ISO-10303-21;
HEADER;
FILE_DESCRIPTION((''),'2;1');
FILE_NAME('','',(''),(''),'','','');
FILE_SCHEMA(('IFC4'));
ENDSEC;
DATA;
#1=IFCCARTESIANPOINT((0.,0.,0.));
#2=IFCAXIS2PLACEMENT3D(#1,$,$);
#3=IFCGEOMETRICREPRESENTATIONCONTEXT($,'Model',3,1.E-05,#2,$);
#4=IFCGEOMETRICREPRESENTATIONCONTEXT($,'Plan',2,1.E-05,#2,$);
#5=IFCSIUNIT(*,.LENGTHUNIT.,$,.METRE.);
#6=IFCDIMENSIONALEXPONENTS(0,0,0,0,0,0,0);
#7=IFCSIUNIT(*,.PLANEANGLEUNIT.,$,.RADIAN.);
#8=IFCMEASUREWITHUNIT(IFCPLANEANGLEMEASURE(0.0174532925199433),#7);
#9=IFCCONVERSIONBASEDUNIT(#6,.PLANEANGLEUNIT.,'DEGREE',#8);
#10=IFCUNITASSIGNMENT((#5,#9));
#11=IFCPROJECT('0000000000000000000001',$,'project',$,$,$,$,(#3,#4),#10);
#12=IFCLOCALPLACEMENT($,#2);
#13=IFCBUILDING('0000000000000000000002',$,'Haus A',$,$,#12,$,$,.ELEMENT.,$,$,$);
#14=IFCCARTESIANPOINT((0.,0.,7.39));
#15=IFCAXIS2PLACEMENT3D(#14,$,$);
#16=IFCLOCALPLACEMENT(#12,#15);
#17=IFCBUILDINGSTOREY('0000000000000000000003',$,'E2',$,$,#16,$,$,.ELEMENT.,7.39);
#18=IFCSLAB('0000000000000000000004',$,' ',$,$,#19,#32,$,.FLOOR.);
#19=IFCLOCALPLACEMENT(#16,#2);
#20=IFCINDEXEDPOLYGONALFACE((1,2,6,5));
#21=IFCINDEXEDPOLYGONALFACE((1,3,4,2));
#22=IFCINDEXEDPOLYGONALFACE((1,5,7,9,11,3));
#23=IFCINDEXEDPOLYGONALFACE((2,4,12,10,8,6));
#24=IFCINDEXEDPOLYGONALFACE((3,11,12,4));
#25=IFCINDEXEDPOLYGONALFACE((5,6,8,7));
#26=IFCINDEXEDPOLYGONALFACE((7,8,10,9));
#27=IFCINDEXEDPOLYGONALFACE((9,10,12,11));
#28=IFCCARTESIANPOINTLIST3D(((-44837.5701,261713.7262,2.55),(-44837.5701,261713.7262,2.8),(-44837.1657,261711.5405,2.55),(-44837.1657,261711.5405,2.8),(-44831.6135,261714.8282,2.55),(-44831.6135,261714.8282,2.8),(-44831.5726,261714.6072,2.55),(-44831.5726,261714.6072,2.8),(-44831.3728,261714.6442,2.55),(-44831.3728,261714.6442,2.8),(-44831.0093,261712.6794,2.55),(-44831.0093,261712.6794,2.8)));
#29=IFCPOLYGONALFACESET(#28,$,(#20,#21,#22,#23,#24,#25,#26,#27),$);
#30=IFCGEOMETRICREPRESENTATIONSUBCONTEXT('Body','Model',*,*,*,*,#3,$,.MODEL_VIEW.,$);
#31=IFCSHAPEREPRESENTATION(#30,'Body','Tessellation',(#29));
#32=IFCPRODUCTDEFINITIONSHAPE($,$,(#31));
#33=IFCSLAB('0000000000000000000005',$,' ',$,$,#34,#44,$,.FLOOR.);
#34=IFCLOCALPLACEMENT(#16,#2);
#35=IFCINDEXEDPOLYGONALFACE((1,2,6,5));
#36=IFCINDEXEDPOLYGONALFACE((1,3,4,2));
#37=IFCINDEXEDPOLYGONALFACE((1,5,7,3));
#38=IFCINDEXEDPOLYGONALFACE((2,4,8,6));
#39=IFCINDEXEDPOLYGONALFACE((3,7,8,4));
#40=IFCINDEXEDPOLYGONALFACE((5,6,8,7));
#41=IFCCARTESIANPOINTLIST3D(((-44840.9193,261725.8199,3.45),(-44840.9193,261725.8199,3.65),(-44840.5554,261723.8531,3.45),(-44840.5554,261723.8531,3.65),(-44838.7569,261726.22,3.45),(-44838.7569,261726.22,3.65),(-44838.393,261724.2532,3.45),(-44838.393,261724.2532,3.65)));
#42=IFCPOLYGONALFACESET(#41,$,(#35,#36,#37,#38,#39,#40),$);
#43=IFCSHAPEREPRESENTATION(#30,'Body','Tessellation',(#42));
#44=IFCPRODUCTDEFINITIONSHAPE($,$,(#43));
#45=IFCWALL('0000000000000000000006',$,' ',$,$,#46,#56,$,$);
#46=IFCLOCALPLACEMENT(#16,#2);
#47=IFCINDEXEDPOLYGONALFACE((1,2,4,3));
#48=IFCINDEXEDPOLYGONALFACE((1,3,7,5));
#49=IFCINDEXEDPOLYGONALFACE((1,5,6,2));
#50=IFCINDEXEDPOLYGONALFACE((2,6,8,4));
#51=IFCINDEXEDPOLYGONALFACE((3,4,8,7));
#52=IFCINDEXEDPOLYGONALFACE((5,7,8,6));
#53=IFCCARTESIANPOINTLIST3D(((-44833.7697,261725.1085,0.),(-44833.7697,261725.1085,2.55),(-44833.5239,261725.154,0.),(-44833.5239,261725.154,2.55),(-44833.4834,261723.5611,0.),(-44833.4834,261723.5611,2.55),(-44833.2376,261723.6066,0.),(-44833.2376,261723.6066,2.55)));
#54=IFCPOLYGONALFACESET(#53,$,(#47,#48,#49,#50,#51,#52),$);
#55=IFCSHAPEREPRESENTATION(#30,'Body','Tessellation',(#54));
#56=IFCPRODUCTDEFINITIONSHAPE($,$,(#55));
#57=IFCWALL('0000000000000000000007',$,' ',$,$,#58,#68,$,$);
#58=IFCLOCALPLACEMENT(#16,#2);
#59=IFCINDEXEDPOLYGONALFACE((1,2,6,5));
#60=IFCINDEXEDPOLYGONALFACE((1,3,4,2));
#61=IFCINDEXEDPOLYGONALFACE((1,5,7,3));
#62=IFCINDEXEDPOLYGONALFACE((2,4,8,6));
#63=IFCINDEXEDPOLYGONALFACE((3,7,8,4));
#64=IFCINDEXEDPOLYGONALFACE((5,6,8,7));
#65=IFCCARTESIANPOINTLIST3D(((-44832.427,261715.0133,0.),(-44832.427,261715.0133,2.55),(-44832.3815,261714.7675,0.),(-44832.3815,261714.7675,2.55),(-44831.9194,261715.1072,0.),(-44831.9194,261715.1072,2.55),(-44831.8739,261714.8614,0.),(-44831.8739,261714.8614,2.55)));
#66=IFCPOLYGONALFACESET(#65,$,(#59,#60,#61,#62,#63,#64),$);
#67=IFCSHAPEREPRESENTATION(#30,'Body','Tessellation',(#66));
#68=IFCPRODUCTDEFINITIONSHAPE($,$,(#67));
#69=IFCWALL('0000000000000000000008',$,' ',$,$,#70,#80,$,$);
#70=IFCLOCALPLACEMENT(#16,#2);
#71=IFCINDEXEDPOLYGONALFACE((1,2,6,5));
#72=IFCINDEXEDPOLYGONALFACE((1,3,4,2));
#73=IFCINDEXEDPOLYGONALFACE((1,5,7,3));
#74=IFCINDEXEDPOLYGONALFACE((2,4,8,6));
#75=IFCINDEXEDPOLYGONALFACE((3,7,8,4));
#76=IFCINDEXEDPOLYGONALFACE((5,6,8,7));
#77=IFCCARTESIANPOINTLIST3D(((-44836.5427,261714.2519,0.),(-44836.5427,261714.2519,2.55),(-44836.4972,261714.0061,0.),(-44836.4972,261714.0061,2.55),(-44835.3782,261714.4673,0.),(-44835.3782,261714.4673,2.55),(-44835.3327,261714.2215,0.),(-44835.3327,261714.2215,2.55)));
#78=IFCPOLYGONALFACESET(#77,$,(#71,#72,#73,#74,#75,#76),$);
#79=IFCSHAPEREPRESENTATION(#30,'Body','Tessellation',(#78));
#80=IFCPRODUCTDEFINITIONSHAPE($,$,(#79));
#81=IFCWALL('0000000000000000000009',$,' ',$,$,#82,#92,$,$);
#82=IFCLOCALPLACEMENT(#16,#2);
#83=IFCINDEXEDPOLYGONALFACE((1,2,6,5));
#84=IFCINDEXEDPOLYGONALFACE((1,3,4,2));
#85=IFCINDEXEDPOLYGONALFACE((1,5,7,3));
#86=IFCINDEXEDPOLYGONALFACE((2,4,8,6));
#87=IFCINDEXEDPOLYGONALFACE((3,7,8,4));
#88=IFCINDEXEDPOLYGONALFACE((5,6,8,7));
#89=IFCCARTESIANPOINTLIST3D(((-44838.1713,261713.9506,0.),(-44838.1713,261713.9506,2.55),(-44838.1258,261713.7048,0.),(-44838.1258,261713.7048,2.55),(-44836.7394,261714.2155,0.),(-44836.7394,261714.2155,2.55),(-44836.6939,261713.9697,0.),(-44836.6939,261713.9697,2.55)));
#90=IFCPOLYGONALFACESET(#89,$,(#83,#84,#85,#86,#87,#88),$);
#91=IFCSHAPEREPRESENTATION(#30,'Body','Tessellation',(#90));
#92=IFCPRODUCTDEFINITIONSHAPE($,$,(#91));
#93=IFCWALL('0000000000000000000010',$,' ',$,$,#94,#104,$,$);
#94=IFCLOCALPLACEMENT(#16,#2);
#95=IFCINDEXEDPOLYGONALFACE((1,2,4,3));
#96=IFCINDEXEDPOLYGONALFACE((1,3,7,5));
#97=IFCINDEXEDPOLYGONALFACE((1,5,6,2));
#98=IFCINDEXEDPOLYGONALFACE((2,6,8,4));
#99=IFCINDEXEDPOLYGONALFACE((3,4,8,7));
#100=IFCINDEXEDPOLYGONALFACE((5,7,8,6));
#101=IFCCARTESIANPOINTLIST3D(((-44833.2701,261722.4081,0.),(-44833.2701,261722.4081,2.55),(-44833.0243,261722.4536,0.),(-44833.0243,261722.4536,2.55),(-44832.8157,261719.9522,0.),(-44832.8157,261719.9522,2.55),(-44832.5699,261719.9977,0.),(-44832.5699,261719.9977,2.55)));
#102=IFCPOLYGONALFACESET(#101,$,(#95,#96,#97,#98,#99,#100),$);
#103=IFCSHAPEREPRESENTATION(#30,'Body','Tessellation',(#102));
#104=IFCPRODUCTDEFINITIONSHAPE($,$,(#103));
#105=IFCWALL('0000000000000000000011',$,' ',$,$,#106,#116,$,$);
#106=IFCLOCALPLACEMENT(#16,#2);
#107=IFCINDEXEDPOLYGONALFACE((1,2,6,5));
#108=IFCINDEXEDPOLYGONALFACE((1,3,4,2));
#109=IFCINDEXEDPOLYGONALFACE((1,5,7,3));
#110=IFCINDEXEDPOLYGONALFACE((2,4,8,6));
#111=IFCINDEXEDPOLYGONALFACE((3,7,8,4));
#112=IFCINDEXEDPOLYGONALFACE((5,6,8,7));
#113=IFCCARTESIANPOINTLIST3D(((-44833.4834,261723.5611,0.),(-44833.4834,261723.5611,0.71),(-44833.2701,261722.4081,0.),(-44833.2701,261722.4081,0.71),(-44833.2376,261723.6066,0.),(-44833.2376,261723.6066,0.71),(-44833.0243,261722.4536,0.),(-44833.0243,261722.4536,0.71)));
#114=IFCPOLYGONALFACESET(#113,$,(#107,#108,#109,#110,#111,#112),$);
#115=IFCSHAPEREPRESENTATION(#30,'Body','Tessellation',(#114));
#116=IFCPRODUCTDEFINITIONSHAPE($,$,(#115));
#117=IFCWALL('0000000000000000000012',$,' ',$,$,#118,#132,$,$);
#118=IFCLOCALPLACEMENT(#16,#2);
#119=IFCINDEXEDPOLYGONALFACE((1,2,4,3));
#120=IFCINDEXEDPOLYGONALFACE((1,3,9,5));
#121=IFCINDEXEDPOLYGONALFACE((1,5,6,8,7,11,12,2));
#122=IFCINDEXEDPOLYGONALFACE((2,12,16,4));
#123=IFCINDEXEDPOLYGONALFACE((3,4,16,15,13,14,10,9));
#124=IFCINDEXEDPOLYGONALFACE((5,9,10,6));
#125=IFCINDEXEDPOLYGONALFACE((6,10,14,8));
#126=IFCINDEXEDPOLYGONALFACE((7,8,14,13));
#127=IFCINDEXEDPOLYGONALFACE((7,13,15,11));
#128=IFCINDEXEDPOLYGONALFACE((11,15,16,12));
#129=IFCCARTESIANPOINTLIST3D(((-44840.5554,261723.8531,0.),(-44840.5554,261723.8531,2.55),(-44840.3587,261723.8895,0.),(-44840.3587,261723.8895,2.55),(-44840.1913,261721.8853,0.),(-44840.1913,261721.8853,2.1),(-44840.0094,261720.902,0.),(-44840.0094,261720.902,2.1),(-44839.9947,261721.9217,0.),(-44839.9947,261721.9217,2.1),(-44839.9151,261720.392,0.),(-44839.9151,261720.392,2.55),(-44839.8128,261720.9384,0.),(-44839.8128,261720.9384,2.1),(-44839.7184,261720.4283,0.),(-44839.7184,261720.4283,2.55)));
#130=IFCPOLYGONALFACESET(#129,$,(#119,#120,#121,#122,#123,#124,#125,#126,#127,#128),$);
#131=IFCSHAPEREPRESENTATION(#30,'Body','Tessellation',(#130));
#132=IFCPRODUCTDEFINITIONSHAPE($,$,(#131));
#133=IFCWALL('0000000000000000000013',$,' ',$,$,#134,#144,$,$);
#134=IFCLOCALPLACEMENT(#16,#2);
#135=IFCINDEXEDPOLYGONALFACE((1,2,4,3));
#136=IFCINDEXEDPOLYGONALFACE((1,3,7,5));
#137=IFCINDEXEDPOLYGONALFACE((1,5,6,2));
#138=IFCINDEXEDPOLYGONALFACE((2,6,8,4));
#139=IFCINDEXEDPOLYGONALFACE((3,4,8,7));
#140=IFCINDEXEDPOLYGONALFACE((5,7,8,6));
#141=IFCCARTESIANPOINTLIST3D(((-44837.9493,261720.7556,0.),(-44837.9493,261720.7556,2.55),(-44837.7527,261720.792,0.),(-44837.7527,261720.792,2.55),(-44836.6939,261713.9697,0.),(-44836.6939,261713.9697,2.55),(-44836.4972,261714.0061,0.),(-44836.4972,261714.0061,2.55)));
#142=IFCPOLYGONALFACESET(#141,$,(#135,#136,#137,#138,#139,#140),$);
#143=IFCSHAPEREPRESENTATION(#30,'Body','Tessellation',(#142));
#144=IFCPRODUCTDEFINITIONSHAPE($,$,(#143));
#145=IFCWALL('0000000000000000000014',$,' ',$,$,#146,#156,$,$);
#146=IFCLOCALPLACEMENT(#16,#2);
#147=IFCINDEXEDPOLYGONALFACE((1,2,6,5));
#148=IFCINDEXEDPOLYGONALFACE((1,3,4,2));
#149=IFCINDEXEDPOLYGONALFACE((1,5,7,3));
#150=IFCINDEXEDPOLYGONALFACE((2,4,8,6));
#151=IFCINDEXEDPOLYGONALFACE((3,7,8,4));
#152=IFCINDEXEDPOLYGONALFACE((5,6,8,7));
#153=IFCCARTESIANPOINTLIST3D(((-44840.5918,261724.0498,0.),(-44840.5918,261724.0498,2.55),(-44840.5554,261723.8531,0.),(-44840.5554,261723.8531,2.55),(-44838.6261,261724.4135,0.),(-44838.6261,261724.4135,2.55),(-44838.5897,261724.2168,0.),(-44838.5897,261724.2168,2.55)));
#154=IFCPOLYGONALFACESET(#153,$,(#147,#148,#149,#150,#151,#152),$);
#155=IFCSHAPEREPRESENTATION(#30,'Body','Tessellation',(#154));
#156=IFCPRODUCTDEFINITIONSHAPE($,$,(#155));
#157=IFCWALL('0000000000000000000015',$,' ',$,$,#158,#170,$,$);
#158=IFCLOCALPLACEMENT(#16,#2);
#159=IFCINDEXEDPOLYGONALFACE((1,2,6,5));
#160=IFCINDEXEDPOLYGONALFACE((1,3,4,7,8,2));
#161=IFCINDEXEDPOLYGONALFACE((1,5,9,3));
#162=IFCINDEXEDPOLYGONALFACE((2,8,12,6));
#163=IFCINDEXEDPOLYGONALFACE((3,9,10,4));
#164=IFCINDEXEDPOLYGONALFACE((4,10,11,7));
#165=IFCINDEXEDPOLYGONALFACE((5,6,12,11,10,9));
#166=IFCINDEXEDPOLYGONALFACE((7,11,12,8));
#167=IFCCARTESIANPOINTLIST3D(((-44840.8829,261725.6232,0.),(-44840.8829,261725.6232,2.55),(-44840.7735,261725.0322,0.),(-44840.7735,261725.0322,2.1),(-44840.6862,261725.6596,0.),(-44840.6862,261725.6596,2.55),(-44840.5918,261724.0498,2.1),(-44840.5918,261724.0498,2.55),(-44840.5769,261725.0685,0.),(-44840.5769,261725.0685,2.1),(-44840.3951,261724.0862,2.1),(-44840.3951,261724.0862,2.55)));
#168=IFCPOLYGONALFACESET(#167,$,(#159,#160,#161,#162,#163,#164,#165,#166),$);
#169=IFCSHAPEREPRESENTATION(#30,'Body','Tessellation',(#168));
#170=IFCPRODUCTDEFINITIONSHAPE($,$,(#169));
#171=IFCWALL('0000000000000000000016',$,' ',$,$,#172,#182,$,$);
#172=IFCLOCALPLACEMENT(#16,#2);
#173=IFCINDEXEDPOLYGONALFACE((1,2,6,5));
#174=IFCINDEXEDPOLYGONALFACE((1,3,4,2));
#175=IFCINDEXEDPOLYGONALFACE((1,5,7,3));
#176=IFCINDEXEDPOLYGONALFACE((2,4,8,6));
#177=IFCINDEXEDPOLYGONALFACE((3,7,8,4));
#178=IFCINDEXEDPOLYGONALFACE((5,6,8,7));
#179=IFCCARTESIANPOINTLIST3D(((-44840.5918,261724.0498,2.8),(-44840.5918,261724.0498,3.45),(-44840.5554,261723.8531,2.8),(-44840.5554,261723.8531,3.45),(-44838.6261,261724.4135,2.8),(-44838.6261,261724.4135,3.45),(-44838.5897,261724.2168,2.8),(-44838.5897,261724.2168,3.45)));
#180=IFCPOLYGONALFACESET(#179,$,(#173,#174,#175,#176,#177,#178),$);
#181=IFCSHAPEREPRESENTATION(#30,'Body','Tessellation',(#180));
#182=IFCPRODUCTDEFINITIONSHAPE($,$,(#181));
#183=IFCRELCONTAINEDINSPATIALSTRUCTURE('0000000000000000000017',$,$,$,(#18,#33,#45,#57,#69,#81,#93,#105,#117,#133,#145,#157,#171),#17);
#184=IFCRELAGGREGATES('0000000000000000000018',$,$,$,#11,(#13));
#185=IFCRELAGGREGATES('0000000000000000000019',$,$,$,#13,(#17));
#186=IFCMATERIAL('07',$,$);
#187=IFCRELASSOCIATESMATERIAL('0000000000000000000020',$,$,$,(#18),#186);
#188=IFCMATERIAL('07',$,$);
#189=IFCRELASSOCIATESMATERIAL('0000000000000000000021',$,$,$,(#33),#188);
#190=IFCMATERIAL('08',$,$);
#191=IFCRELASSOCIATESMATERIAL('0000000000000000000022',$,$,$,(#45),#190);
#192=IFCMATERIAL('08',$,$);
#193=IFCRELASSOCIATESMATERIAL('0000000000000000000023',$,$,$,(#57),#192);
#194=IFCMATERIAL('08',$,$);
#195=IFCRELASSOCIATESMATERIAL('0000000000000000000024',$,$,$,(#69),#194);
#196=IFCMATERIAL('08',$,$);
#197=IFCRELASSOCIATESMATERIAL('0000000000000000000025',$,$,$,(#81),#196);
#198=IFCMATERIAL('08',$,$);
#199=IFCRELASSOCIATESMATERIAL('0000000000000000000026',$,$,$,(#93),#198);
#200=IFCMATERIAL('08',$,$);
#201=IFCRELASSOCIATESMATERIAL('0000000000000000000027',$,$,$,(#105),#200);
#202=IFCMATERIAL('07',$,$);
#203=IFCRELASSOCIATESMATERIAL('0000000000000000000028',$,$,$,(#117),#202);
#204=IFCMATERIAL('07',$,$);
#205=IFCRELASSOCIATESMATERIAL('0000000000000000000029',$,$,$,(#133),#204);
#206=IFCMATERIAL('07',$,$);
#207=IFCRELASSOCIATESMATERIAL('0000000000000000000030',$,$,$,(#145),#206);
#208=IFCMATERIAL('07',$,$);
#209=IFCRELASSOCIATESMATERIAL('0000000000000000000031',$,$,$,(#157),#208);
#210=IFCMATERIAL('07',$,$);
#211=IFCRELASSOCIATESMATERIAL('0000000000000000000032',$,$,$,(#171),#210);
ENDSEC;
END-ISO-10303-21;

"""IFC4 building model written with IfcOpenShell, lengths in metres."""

from ifc_helpers import new_model, entity, si_unit, converted_unit, frame, frame_2d, origin, origin_with_axes, place, context, subcontext, project, spatial, polyline, rectangle, outline, extrude, material, element, save


model = new_model("IFC4")

# Units and contexts
model_context = context("Model", 3, precision=1e-05, world=origin())
plan_context = context("Plan", 2, precision=1e-05, world=origin())
body_context = subcontext(model_context, "Body", "Model", "MODEL_VIEW")
ifc_project = project(units=[si_unit("LENGTHUNIT", "METRE"), converted_unit("PLANEANGLEUNIT", "DEGREE", entity("IfcPlaneAngleMeasure", 0.0174532925199433), si_unit("PLANEANGLEUNIT", "RADIAN"), dimensions=[0, 0, 0, 0, 0, 0, 0])], contexts=[model_context, plan_context])

# Building, storey
building_placement = place(None, origin())
building = spatial("IfcBuilding", under=ifc_project, at=building_placement, Name="Haus A", CompositionType="ELEMENT")
storey_placement = place(building_placement, frame((0.0, 0.0, 7.39)))
storey = spatial("IfcBuildingStorey", under=building, at=storey_placement, Name="E2", CompositionType="ELEMENT", Elevation=7.39)

# Slabs
ifc_material_1 = material(Name="07")
slab_1_placement = place(storey_placement, frame((-44837.5701, 261711.5405, 2.55)))
element("IfcSlab", 1, at=slab_1_placement, inside=storey, material=ifc_material_1, Name=" ", PredefinedType="FLOOR", context=body_context, shape_type="SweptSolid", body=[
    extrude(outline(polyline([(0.0, 2.1858), (0.4044, 0.0), (6.5608, 1.139), (6.1973, 3.1037), (5.9975, 3.0667), (5.9566, 3.2878), (0.0, 2.1858)])), origin_with_axes(), (0.0, 0.0, 1.0), 0.25),
])
ifc_material_2 = material(Name="07")
slab_2_placement = place(storey_placement, frame((-44840.9193, 261723.8531, 3.45)))
element("IfcSlab", 2, at=slab_2_placement, inside=storey, material=ifc_material_2, Name=" ", PredefinedType="FLOOR", context=body_context, shape_type="SweptSolid", body=[
    extrude(rectangle(XDim=2.0001, YDim=2.1991, at=frame_2d((1.2631, -0.7834), x_axis=(0.18192, -0.983313))), frame((0.0, 1.9668, 0.0), z_axis=(0.0, 0.0, 1.0), x_axis=(1.0, 0.0, 0.0)), (0.0, 0.0, 1.0), 0.2),
])

# Walls
ifc_material_3 = material(Name="08")
wall_1_placement = place(storey_placement, frame((-44833.2376, 261723.6066, 0.0), z_axis=(0.0, 0.0, 1.0), x_axis=(-0.18192, 0.983313, 0.0)))
element("IfcWall", 3, at=wall_1_placement, inside=storey, material=ifc_material_3, Name=" ", context=body_context, shape_type="SweptSolid", body=[
    extrude(rectangle(XDim=1.5737, YDim=0.25, at=frame_2d((0.7868, 0.125), x_axis=(1.0, 0.0))), origin_with_axes(), (0.0, 0.0, 1.0), 2.55),
])
ifc_material_4 = material(Name="08")
wall_2_placement = place(storey_placement, frame((-44832.3815, 261714.7675, 0.0), z_axis=(0.0, 0.0, 1.0), x_axis=(0.983313, 0.18192, 0.0)))
element("IfcWall", 4, at=wall_2_placement, inside=storey, material=ifc_material_4, Name=" ", context=body_context, shape_type="SweptSolid", body=[
    extrude(rectangle(XDim=0.5162, YDim=0.25, at=frame_2d((0.2581, 0.125), x_axis=(1.0, 0.0))), origin_with_axes(), (0.0, 0.0, 1.0), 2.55),
])
ifc_material_5 = material(Name="08")
wall_3_placement = place(storey_placement, frame((-44836.4972, 261714.0061, 0.0), z_axis=(0.0, 0.0, 1.0), x_axis=(0.983313, 0.18192, 0.0)))
element("IfcWall", 5, at=wall_3_placement, inside=storey, material=ifc_material_5, Name=" ", context=body_context, shape_type="SweptSolid", body=[
    extrude(rectangle(XDim=1.1842, YDim=0.25, at=frame_2d((0.5921, 0.125), x_axis=(1.0, 0.0))), origin_with_axes(), (0.0, 0.0, 1.0), 2.55),
])
ifc_material_6 = material(Name="08")
wall_4_placement = place(storey_placement, frame((-44838.1258, 261713.7048, 0.0), z_axis=(0.0, 0.0, 1.0), x_axis=(0.983313, 0.18192, 0.0)))
element("IfcWall", 6, at=wall_4_placement, inside=storey, material=ifc_material_6, Name=" ", context=body_context, shape_type="SweptSolid", body=[
    extrude(rectangle(XDim=1.4562, YDim=0.25, at=frame_2d((0.7281, 0.125), x_axis=(1.0, 0.0))), origin_with_axes(), (0.0, 0.0, 1.0), 2.55),
])
ifc_material_7 = material(Name="08")
wall_5_placement = place(storey_placement, frame((-44832.5699, 261719.9977, 0.0), z_axis=(0.0, 0.0, 1.0), x_axis=(-0.18192, 0.983313, 0.0)))
element("IfcWall", 7, at=wall_5_placement, inside=storey, material=ifc_material_7, Name=" ", context=body_context, shape_type="SweptSolid", body=[
    extrude(rectangle(XDim=2.4976, YDim=0.25, at=frame_2d((1.2488, 0.125), x_axis=(1.0, 0.0))), origin_with_axes(), (0.0, 0.0, 1.0), 2.55),
])
ifc_material_8 = material(Name="08")
wall_6_placement = place(storey_placement, frame((-44833.0243, 261722.4536, 0.0), z_axis=(0.0, 0.0, 1.0), x_axis=(-0.18192, 0.983313, 0.0)))
element("IfcWall", 8, at=wall_6_placement, inside=storey, material=ifc_material_8, Name=" ", context=body_context, shape_type="SweptSolid", body=[
    extrude(rectangle(XDim=1.1726, YDim=0.25, at=frame_2d((0.5863, 0.125), x_axis=(1.0, 0.0))), origin_with_axes(), (0.0, 0.0, 1.0), 0.71),
])

# Wall, opening
ifc_material_9 = material(Name="07")
wall_7_placement = place(storey_placement, frame((-44839.7184, 261720.4283, 0.0), z_axis=(0.0, 0.0, 1.0), x_axis=(-0.18192, 0.983313, 0.0)))
wall_7 = element("IfcWall", 9, at=wall_7_placement, inside=storey, material=ifc_material_9, Name=" ", context=body_context, shape_type="SweptSolid", body=[
    extrude(rectangle(XDim=3.5199, YDim=0.2, at=frame_2d((1.76, 0.1), x_axis=(1.0, 0.0))), origin_with_axes(), (0.0, 0.0, 1.0), 2.55),
])
opening_1_placement = place(wall_7_placement, frame((0.5187, 0.0, 0.0), z_axis=(0.0, 1.0, 0.0), x_axis=(0.0, 0.0, 1.0)))
element("IfcOpeningElement", 10, at=opening_1_placement, cuts=wall_7, ObjectType="Opening", context=body_context, shape_type="SweptSolid", body=[
    extrude(outline(polyline([(0.0, 1.0), (2.1, 1.0), (2.1, 0.0), (0.0, 0.0), (0.0, 1.0)])), origin_with_axes(), (0.0, 0.0, 1.0), 0.2),
])

# Walls
ifc_material_10 = material(Name="07")
wall_8_placement = place(storey_placement, frame((-44837.9493, 261720.7556, 0.0), z_axis=(0.0, 0.0, 1.0), x_axis=(0.18192, -0.983313, 0.0)))
element("IfcWall", 11, at=wall_8_placement, inside=storey, material=ifc_material_10, Name=" ", context=body_context, shape_type="SweptSolid", body=[
    extrude(rectangle(XDim=6.9011, YDim=0.2, at=frame_2d((3.4506, 0.1), x_axis=(1.0, 0.0))), origin_with_axes(), (0.0, 0.0, 1.0), 2.55),
])
ifc_material_11 = material(Name="07")
wall_9_placement = place(storey_placement, frame((-44838.6261, 261724.4135, 0.0), z_axis=(0.0, 0.0, 1.0), x_axis=(-0.983313, -0.18192, 0.0)))
element("IfcWall", 12, at=wall_9_placement, inside=storey, material=ifc_material_11, Name=" ", context=body_context, shape_type="SweptSolid", body=[
    extrude(rectangle(XDim=1.9991, YDim=0.2, at=frame_2d((0.9995, 0.1), x_axis=(1.0, 0.0))), origin_with_axes(), (0.0, 0.0, 1.0), 2.55),
])

# Wall, opening
ifc_material_12 = material(Name="07")
wall_10_placement = place(storey_placement, frame((-44840.3951, 261724.0862, 0.0), z_axis=(0.0, 0.0, 1.0), x_axis=(-0.18192, 0.983313, 0.0)))
wall_10 = element("IfcWall", 13, at=wall_10_placement, inside=storey, material=ifc_material_12, Name=" ", context=body_context, shape_type="SweptSolid", body=[
    extrude(rectangle(XDim=1.6001, YDim=0.2, at=frame_2d((0.8001, 0.1), x_axis=(1.0, 0.0))), origin_with_axes(), (0.0, 0.0, 1.0), 2.55),
])
opening_2_placement = place(wall_10_placement, frame((0.0, 0.0, 0.0), z_axis=(0.0, 1.0, 0.0), x_axis=(0.0, 0.0, 1.0)))
element("IfcOpeningElement", 14, at=opening_2_placement, cuts=wall_10, ObjectType="Opening", context=body_context, shape_type="SweptSolid", body=[
    extrude(outline(polyline([(0.0, 0.999), (2.1, 0.999), (2.1, 0.0), (0.0, 0.0), (0.0, 0.999)])), origin_with_axes(), (0.0, 0.0, 1.0), 0.2),
])

# Wall
ifc_material_13 = material(Name="07")
wall_11_placement = place(storey_placement, frame((-44838.6261, 261724.4135, 2.8), z_axis=(0.0, 0.0, 1.0), x_axis=(-0.983313, -0.18192, 0.0)))
element("IfcWall", 15, at=wall_11_placement, inside=storey, material=ifc_material_13, Name=" ", context=body_context, shape_type="SweptSolid", body=[
    extrude(rectangle(XDim=1.9991, YDim=0.2, at=frame_2d((0.9995, 0.1), x_axis=(1.0, 0.0))), origin_with_axes(), (0.0, 0.0, 1.0), 0.65),
])

save(model, "model.ifc")
